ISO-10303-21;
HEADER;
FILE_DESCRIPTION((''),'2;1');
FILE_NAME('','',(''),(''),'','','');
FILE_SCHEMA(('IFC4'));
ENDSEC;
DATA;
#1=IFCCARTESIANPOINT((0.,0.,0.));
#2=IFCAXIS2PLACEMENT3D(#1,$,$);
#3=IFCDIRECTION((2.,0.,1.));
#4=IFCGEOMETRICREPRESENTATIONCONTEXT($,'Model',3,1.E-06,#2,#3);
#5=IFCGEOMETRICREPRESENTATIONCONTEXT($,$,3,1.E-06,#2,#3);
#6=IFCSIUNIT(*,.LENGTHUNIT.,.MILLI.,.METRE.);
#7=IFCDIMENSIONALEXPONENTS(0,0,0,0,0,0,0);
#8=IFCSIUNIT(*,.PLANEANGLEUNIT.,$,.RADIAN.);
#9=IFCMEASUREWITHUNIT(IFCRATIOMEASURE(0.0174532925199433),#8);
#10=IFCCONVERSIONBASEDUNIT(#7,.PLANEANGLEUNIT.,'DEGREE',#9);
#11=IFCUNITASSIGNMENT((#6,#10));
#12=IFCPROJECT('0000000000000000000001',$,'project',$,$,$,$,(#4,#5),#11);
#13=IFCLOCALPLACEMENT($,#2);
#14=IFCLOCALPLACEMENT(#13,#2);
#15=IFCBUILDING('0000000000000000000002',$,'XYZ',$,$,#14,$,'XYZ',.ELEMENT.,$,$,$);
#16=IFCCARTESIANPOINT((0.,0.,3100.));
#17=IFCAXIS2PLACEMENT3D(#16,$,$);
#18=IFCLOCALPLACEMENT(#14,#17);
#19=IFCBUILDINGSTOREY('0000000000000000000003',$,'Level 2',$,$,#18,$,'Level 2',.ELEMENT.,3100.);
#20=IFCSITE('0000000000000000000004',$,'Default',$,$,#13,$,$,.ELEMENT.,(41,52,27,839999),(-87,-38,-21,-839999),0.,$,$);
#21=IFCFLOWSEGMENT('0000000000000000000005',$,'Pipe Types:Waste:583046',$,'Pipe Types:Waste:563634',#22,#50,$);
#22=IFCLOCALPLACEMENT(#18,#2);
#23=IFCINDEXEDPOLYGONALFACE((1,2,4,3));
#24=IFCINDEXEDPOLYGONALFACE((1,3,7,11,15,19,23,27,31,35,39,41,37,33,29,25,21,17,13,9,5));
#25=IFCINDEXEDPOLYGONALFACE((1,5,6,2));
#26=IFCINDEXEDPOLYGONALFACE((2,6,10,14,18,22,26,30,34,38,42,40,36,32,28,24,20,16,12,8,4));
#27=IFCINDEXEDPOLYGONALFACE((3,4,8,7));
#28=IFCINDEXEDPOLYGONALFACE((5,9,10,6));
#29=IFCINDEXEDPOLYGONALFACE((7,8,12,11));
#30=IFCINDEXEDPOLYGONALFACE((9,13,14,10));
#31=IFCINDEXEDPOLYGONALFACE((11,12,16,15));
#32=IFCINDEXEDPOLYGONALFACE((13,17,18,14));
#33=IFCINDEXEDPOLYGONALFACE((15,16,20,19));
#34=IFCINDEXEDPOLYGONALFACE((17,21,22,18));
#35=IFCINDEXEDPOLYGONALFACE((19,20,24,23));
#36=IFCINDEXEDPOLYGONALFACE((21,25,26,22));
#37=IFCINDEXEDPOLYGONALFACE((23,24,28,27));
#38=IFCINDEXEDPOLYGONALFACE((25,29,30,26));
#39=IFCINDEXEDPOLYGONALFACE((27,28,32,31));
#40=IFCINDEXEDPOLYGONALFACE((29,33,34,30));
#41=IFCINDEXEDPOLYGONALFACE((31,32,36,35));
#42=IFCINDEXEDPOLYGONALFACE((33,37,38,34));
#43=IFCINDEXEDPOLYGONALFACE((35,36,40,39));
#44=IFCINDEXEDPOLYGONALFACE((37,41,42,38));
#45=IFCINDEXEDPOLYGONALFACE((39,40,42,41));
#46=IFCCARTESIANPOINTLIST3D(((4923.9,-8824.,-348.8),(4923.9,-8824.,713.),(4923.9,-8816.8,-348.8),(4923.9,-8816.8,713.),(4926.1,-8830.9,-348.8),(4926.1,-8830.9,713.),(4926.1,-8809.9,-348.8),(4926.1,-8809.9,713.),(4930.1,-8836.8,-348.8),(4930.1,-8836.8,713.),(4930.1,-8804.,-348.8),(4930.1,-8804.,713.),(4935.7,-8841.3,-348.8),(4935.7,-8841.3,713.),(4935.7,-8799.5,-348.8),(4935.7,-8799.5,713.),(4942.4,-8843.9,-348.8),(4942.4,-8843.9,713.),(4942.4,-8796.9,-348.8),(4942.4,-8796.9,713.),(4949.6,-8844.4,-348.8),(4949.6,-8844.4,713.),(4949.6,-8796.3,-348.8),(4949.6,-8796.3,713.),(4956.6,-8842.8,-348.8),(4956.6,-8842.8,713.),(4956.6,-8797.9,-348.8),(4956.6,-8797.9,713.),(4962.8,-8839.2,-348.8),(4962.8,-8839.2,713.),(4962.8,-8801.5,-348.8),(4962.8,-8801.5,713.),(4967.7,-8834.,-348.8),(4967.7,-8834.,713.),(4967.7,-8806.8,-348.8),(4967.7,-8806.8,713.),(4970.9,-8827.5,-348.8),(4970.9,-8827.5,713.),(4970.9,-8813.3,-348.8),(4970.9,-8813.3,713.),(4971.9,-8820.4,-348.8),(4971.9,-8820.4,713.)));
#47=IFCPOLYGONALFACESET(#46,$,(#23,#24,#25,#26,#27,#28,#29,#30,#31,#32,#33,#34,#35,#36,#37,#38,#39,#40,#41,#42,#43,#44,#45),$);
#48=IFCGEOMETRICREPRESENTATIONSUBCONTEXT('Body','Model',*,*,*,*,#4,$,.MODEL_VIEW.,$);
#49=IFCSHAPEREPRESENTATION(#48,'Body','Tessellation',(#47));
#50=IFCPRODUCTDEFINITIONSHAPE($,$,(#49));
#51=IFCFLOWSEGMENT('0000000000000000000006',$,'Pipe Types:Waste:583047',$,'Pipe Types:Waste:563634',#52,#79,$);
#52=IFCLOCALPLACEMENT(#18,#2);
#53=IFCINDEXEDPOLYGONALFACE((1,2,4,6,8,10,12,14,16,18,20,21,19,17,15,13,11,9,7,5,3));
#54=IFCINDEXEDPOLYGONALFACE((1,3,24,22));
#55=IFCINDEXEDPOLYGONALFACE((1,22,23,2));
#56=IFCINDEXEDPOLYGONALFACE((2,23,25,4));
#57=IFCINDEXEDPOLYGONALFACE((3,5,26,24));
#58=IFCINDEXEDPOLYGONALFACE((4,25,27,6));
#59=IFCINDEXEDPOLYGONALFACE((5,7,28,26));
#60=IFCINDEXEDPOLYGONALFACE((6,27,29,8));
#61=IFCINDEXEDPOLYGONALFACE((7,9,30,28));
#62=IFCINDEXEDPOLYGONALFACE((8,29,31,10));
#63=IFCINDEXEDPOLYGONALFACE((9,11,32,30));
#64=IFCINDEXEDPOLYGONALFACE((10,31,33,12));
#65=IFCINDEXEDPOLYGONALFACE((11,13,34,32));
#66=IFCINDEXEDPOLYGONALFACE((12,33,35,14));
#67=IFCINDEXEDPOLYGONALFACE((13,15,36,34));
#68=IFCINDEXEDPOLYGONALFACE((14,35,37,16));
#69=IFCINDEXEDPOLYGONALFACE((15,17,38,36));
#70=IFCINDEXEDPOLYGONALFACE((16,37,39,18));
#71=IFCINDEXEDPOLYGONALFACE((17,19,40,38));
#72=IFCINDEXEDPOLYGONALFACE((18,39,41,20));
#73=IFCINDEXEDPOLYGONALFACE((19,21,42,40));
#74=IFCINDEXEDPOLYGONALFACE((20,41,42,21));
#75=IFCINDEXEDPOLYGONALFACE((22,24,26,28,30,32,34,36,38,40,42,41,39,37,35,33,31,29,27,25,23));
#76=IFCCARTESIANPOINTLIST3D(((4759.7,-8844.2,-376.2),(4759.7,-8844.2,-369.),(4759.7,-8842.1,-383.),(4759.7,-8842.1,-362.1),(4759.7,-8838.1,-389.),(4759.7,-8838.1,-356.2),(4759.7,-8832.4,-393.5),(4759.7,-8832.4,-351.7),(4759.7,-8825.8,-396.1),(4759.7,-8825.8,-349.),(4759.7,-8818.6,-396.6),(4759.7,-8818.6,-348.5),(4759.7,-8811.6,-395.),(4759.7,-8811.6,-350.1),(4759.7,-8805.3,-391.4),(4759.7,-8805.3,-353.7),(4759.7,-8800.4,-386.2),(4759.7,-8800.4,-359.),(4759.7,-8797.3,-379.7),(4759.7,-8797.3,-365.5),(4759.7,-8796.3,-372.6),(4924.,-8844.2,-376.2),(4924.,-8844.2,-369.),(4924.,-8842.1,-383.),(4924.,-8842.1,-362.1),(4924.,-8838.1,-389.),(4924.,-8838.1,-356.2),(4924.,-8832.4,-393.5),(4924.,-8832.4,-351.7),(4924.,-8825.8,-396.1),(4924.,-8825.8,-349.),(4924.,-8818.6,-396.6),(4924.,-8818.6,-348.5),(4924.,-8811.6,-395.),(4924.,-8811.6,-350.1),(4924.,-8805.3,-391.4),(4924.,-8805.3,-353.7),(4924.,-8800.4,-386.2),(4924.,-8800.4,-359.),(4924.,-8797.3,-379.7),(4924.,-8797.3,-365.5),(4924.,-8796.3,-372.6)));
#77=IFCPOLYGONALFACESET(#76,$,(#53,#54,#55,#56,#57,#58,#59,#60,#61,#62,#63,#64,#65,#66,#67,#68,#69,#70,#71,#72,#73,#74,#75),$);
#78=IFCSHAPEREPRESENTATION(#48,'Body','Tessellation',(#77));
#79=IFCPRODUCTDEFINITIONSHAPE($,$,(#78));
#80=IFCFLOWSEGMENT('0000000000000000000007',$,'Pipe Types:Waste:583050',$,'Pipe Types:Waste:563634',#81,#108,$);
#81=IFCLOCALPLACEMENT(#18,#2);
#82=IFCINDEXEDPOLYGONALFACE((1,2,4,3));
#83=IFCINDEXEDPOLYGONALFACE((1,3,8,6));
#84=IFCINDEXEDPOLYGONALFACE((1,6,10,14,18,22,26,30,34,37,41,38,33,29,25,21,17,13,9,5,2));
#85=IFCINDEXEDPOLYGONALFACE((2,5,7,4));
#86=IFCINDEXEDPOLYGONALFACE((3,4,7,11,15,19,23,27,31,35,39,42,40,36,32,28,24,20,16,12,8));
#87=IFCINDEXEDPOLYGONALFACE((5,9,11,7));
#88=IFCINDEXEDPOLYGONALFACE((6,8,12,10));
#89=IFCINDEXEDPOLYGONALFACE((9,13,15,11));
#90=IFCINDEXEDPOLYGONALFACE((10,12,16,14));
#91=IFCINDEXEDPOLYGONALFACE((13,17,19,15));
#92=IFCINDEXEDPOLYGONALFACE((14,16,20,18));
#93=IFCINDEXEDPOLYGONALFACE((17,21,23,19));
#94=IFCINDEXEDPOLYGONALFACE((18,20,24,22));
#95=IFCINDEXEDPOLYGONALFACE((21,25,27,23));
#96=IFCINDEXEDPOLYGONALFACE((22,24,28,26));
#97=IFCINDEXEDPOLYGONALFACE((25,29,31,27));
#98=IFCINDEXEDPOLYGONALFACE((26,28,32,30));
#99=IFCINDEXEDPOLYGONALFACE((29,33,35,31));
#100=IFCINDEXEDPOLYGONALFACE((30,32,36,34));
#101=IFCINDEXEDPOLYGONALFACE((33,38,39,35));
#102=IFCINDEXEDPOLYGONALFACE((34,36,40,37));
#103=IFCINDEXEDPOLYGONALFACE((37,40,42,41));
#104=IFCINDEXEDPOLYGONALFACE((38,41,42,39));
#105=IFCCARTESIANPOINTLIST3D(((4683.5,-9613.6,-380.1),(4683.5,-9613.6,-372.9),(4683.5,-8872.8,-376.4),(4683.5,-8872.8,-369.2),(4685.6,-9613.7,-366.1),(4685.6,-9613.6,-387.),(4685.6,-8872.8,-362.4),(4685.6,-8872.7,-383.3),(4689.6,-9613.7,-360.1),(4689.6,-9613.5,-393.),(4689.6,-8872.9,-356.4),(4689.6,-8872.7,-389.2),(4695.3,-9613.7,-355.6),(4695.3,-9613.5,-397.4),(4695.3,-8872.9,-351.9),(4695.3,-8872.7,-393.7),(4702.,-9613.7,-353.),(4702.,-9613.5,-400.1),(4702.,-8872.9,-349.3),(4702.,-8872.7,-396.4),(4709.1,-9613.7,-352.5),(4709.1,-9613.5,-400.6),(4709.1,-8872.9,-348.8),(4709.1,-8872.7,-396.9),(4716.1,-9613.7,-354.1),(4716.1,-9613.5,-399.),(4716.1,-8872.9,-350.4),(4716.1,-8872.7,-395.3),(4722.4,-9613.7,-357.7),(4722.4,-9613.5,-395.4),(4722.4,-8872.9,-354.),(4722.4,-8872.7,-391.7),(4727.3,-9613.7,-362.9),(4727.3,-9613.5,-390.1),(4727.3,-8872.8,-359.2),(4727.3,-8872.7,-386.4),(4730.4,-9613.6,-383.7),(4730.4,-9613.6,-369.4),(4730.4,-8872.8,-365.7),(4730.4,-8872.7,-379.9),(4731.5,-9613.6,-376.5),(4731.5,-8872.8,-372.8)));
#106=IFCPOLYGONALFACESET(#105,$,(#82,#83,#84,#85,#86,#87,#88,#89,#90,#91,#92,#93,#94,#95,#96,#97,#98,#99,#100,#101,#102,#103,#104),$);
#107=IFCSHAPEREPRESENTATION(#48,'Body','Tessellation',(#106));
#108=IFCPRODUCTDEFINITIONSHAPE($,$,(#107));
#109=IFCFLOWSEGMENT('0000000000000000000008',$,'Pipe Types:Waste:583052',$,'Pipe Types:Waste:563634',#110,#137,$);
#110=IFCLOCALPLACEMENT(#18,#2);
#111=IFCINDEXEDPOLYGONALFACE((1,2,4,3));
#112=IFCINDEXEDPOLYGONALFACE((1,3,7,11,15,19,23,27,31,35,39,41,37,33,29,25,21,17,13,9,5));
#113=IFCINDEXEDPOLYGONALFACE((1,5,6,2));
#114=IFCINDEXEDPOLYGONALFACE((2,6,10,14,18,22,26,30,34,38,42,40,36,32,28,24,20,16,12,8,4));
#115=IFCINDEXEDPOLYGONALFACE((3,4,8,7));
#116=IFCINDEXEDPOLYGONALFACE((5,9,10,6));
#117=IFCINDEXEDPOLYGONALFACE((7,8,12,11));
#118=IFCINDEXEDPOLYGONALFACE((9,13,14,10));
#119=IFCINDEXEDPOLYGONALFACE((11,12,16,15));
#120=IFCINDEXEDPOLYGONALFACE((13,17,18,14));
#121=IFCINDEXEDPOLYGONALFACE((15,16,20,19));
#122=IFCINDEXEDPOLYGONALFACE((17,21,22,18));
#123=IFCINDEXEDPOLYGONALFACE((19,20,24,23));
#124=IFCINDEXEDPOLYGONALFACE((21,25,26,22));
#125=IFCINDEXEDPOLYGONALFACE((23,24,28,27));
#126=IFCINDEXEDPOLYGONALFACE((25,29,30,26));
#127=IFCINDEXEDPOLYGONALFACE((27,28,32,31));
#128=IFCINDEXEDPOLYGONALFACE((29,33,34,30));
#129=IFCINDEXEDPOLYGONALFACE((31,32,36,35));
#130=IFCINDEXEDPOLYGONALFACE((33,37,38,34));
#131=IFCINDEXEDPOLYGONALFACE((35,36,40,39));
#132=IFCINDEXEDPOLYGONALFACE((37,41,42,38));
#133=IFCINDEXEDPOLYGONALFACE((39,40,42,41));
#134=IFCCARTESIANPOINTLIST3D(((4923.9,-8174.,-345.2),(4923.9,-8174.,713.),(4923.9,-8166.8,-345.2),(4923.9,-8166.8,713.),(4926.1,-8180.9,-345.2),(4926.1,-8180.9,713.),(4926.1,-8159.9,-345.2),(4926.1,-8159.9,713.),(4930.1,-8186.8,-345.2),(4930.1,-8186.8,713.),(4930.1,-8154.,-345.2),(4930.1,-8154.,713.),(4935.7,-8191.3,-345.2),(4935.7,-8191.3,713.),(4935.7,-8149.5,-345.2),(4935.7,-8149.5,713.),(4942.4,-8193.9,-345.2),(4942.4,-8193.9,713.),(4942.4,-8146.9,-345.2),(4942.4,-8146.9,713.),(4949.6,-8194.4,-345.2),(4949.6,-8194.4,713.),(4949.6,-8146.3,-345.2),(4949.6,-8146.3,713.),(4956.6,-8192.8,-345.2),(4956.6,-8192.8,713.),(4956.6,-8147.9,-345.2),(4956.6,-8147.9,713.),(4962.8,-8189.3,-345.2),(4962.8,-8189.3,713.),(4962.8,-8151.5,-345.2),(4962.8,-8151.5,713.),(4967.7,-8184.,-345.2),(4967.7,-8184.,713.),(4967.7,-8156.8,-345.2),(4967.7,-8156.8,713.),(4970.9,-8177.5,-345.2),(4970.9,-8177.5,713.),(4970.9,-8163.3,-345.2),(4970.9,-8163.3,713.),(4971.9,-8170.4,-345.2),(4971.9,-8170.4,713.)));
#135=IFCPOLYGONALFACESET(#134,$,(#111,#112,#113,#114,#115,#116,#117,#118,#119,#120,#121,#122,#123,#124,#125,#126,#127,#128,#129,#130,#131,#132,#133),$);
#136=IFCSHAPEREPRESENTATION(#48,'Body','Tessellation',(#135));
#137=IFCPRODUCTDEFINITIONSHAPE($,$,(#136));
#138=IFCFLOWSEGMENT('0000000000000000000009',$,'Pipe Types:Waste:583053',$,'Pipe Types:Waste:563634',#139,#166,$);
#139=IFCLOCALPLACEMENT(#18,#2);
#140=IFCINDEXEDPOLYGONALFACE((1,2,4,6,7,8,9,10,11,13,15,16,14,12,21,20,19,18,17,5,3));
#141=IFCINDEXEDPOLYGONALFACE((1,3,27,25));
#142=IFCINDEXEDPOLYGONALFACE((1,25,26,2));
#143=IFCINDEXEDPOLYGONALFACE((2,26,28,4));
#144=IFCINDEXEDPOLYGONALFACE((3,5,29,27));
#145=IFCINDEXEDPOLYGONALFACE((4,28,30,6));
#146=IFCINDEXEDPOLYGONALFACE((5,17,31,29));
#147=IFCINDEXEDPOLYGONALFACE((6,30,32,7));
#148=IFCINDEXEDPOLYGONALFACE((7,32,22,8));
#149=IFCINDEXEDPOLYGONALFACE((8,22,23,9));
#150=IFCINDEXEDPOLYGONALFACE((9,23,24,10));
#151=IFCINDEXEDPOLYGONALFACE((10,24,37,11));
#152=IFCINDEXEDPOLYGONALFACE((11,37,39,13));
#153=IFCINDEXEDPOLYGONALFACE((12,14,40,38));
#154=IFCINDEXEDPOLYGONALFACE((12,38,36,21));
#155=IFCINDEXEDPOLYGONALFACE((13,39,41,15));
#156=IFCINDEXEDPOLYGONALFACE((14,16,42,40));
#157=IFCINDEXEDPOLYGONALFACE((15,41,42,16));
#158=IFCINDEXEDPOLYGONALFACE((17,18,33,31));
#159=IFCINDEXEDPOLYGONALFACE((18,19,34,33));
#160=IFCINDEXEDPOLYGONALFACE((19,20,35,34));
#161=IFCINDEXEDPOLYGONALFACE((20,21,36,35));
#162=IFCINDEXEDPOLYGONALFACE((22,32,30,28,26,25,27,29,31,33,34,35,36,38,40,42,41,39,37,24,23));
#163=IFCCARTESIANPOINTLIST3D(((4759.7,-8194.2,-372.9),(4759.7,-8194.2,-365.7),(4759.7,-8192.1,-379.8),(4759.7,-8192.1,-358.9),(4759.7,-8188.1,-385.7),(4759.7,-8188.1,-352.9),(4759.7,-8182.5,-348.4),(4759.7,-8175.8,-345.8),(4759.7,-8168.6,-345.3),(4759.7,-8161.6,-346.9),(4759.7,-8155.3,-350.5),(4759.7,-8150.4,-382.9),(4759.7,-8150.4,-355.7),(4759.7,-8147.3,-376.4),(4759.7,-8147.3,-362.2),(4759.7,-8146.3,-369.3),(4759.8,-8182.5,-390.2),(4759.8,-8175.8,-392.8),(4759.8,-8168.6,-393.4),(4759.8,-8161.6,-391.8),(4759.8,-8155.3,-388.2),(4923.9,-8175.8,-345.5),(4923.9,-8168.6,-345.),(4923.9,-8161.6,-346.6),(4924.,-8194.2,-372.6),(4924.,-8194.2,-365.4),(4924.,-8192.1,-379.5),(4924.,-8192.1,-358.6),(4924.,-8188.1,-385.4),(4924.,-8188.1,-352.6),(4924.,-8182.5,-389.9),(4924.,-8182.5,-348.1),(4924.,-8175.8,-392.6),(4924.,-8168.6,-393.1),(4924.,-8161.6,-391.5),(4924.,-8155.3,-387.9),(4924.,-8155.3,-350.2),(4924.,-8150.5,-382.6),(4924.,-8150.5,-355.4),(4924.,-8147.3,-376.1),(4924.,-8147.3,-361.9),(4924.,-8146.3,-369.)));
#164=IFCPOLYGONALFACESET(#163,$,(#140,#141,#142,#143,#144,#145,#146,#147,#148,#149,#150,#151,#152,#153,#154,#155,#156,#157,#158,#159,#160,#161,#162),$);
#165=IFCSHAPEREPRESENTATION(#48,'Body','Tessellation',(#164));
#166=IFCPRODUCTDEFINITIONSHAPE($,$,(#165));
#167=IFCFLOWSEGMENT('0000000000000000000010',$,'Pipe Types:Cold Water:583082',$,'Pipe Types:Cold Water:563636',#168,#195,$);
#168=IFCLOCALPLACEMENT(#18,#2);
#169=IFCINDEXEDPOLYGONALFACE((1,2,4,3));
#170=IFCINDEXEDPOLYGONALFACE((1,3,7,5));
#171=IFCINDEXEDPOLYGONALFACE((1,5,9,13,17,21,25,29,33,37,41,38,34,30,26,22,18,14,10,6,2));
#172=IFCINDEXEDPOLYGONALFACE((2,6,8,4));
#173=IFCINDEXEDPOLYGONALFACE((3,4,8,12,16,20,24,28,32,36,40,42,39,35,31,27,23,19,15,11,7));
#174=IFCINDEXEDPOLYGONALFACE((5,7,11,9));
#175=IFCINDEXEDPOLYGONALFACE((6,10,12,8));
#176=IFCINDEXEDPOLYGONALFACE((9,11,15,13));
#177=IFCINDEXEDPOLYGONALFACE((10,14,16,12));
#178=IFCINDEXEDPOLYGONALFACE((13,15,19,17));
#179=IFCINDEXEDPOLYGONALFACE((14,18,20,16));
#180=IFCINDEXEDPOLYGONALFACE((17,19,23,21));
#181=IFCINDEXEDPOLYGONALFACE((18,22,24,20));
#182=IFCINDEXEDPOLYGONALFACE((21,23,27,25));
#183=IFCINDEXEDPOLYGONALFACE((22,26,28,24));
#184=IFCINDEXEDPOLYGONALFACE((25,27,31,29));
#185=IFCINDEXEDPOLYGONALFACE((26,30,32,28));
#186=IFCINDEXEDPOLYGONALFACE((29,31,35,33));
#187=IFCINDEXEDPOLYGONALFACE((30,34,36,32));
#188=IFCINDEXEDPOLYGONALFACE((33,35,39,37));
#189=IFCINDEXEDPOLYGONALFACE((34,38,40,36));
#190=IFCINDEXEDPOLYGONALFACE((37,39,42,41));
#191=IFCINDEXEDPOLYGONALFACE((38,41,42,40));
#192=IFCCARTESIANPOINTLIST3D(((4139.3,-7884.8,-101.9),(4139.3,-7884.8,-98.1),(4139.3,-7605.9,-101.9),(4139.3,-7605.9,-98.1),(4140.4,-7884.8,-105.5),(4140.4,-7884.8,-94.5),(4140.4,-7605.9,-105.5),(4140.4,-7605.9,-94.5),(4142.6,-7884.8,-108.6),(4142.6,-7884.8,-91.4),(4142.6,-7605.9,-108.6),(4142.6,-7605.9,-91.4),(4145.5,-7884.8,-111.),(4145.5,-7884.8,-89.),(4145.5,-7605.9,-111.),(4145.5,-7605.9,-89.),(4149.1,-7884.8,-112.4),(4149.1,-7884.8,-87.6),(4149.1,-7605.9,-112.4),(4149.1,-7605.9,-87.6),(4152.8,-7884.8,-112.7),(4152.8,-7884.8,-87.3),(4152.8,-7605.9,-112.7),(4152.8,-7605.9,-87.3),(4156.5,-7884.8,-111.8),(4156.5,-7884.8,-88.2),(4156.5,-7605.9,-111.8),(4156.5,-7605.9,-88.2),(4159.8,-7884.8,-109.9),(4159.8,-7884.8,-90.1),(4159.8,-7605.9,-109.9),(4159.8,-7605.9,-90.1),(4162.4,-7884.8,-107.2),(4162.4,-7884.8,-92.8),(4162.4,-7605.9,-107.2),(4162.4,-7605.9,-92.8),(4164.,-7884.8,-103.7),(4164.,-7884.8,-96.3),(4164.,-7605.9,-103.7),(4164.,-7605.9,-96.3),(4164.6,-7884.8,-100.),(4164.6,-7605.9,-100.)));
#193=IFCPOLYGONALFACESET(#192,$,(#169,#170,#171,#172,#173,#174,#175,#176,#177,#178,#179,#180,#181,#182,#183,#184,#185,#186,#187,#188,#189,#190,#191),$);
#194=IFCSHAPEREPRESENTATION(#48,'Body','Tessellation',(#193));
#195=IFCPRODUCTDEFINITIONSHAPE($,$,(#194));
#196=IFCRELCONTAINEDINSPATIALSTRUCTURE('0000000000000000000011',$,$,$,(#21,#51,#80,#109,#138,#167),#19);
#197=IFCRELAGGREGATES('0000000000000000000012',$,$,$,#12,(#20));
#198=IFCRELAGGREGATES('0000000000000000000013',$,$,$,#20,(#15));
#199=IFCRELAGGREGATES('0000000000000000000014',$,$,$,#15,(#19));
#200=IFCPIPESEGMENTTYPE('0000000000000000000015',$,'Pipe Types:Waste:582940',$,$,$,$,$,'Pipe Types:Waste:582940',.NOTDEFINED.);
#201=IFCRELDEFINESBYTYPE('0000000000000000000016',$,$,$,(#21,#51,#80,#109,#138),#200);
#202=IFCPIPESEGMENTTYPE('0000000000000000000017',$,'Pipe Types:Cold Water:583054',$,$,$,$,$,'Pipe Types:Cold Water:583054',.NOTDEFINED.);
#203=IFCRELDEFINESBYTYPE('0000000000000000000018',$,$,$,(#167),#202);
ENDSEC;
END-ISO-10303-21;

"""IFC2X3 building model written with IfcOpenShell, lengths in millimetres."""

from ifc_helpers import new_model, entity, si_unit, converted_unit, direction, frame, frame_2d, origin, origin_2d_with_axis, place, context, subcontext, project, spatial, circle, extrude, type_object, element, save


model = new_model("IFC2X3")

# Units and contexts
model_context = context("Model", 3, precision=1e-06, world=origin(), true_north=direction((2.0, 0.0, 1.0)))
context_of_model = context(None, 3, precision=1e-06, world=origin(), true_north=direction((2.0, 0.0, 1.0)))
body_context = subcontext(model_context, "Body", "Model", "MODEL_VIEW")
ifc_project = project(units=[si_unit("LENGTHUNIT", "METRE", prefix="MILLI"), converted_unit("PLANEANGLEUNIT", "DEGREE", entity("IfcRatioMeasure", 0.0174532925199433), si_unit("PLANEANGLEUNIT", "RADIAN"), dimensions=[0, 0, 0, 0, 0, 0, 0])], contexts=[model_context, context_of_model])

# Site, building, storey
site_placement = place(None, origin())
site = spatial("IfcSite", under=ifc_project, at=site_placement, Name="Default", CompositionType="ELEMENT", RefLatitude=(41, 52, 27, 839999), RefLongitude=(-87, -38, -21, -839999), RefElevation=0.0)
building_placement = place(site_placement, origin())
building = spatial("IfcBuilding", under=site, at=building_placement, Name="XYZ", LongName="XYZ", CompositionType="ELEMENT")
storey_placement = place(building_placement, frame((0.0, 0.0, 3100.0)))
storey = spatial("IfcBuildingStorey", under=building, at=storey_placement, Name="Level 2", LongName="Level 2", CompositionType="ELEMENT", Elevation=3100.0)

# Flow segments
pipe_segment_type_1 = type_object("IfcPipeSegmentType", Name="Pipe Types:Waste:582940", ElementType="Pipe Types:Waste:582940", PredefinedType="NOTDEFINED")
flow_segment_1_placement = place(storey_placement, origin())
element("IfcFlowSegment", 1, at=flow_segment_1_placement, inside=storey, type_object=pipe_segment_type_1, Name="Pipe Types:Waste:583046", ObjectType="Pipe Types:Waste:563634", context=body_context, shape_type="SweptSolid", body=[
    extrude(circle(Radius=24.1, at=origin_2d_with_axis()), frame((4947.8, -8820.4, -348.8)), (0.0, 0.0, 1.0), 1061.8),
])
flow_segment_2_placement = place(storey_placement, origin())
element("IfcFlowSegment", 2, at=flow_segment_2_placement, inside=storey, type_object=pipe_segment_type_1, Name="Pipe Types:Waste:583047", ObjectType="Pipe Types:Waste:563634", context=body_context, shape_type="SweptSolid", body=[
    extrude(circle(Radius=24.1, at=frame_2d((0.0, 0.0), x_axis=(1.0, 0.0))), frame((4759.7, -8820.4, -372.6), z_axis=(1.0, 0.0, 0.0), x_axis=(0.0, 1.0, 0.0)), (0.0, 0.0, 1.0), 164.3),
])
flow_segment_3_placement = place(storey_placement, origin())
element("IfcFlowSegment", 3, at=flow_segment_3_placement, inside=storey, type_object=pipe_segment_type_1, Name="Pipe Types:Waste:583050", ObjectType="Pipe Types:Waste:563634", context=body_context, shape_type="SweptSolid", body=[
    extrude(circle(Radius=24.1, at=origin_2d_with_axis()), frame((4707.3, -9613.6, -376.5), z_axis=(0.0, 0.999988, 0.005), x_axis=(1.0, 0.0, 0.0)), (0.0, 0.0, 1.0), 740.9),
])
flow_segment_4_placement = place(storey_placement, origin())
element("IfcFlowSegment", 4, at=flow_segment_4_placement, inside=storey, type_object=pipe_segment_type_1, Name="Pipe Types:Waste:583052", ObjectType="Pipe Types:Waste:563634", context=body_context, shape_type="SweptSolid", body=[
    extrude(circle(Radius=24.1, at=origin_2d_with_axis()), frame((4947.8, -8170.4, -345.2)), (0.0, 0.0, 1.0), 1058.2),
])
flow_segment_5_placement = place(storey_placement, origin())
element("IfcFlowSegment", 5, at=flow_segment_5_placement, inside=storey, type_object=pipe_segment_type_1, Name="Pipe Types:Waste:583053", ObjectType="Pipe Types:Waste:563634", context=body_context, shape_type="SweptSolid", body=[
    extrude(circle(Radius=24.1, at=frame_2d((0.0, 0.0), x_axis=(1.0, 0.0))), frame((4759.7, -8170.4, -369.3), z_axis=(0.999998, -0.000009, 0.001751), x_axis=(0.000009, 1.0, 0.0)), (0.0, 0.0, 1.0), 164.3),
])
pipe_segment_type_2 = type_object("IfcPipeSegmentType", Name="Pipe Types:Cold Water:583054", ElementType="Pipe Types:Cold Water:583054", PredefinedType="NOTDEFINED")
flow_segment_6_placement = place(storey_placement, origin())
element("IfcFlowSegment", 6, at=flow_segment_6_placement, inside=storey, type_object=pipe_segment_type_2, Name="Pipe Types:Cold Water:583082", ObjectType="Pipe Types:Cold Water:563636", context=body_context, shape_type="SweptSolid", body=[
    extrude(circle(Radius=12.7, at=origin_2d_with_axis()), frame((4151.9, -7884.8, -100.0), z_axis=(0.0, 1.0, 0.0), x_axis=(1.0, 0.0, 0.0)), (0.0, 0.0, 1.0), 278.9),
])

save(model, "model.ifc")
